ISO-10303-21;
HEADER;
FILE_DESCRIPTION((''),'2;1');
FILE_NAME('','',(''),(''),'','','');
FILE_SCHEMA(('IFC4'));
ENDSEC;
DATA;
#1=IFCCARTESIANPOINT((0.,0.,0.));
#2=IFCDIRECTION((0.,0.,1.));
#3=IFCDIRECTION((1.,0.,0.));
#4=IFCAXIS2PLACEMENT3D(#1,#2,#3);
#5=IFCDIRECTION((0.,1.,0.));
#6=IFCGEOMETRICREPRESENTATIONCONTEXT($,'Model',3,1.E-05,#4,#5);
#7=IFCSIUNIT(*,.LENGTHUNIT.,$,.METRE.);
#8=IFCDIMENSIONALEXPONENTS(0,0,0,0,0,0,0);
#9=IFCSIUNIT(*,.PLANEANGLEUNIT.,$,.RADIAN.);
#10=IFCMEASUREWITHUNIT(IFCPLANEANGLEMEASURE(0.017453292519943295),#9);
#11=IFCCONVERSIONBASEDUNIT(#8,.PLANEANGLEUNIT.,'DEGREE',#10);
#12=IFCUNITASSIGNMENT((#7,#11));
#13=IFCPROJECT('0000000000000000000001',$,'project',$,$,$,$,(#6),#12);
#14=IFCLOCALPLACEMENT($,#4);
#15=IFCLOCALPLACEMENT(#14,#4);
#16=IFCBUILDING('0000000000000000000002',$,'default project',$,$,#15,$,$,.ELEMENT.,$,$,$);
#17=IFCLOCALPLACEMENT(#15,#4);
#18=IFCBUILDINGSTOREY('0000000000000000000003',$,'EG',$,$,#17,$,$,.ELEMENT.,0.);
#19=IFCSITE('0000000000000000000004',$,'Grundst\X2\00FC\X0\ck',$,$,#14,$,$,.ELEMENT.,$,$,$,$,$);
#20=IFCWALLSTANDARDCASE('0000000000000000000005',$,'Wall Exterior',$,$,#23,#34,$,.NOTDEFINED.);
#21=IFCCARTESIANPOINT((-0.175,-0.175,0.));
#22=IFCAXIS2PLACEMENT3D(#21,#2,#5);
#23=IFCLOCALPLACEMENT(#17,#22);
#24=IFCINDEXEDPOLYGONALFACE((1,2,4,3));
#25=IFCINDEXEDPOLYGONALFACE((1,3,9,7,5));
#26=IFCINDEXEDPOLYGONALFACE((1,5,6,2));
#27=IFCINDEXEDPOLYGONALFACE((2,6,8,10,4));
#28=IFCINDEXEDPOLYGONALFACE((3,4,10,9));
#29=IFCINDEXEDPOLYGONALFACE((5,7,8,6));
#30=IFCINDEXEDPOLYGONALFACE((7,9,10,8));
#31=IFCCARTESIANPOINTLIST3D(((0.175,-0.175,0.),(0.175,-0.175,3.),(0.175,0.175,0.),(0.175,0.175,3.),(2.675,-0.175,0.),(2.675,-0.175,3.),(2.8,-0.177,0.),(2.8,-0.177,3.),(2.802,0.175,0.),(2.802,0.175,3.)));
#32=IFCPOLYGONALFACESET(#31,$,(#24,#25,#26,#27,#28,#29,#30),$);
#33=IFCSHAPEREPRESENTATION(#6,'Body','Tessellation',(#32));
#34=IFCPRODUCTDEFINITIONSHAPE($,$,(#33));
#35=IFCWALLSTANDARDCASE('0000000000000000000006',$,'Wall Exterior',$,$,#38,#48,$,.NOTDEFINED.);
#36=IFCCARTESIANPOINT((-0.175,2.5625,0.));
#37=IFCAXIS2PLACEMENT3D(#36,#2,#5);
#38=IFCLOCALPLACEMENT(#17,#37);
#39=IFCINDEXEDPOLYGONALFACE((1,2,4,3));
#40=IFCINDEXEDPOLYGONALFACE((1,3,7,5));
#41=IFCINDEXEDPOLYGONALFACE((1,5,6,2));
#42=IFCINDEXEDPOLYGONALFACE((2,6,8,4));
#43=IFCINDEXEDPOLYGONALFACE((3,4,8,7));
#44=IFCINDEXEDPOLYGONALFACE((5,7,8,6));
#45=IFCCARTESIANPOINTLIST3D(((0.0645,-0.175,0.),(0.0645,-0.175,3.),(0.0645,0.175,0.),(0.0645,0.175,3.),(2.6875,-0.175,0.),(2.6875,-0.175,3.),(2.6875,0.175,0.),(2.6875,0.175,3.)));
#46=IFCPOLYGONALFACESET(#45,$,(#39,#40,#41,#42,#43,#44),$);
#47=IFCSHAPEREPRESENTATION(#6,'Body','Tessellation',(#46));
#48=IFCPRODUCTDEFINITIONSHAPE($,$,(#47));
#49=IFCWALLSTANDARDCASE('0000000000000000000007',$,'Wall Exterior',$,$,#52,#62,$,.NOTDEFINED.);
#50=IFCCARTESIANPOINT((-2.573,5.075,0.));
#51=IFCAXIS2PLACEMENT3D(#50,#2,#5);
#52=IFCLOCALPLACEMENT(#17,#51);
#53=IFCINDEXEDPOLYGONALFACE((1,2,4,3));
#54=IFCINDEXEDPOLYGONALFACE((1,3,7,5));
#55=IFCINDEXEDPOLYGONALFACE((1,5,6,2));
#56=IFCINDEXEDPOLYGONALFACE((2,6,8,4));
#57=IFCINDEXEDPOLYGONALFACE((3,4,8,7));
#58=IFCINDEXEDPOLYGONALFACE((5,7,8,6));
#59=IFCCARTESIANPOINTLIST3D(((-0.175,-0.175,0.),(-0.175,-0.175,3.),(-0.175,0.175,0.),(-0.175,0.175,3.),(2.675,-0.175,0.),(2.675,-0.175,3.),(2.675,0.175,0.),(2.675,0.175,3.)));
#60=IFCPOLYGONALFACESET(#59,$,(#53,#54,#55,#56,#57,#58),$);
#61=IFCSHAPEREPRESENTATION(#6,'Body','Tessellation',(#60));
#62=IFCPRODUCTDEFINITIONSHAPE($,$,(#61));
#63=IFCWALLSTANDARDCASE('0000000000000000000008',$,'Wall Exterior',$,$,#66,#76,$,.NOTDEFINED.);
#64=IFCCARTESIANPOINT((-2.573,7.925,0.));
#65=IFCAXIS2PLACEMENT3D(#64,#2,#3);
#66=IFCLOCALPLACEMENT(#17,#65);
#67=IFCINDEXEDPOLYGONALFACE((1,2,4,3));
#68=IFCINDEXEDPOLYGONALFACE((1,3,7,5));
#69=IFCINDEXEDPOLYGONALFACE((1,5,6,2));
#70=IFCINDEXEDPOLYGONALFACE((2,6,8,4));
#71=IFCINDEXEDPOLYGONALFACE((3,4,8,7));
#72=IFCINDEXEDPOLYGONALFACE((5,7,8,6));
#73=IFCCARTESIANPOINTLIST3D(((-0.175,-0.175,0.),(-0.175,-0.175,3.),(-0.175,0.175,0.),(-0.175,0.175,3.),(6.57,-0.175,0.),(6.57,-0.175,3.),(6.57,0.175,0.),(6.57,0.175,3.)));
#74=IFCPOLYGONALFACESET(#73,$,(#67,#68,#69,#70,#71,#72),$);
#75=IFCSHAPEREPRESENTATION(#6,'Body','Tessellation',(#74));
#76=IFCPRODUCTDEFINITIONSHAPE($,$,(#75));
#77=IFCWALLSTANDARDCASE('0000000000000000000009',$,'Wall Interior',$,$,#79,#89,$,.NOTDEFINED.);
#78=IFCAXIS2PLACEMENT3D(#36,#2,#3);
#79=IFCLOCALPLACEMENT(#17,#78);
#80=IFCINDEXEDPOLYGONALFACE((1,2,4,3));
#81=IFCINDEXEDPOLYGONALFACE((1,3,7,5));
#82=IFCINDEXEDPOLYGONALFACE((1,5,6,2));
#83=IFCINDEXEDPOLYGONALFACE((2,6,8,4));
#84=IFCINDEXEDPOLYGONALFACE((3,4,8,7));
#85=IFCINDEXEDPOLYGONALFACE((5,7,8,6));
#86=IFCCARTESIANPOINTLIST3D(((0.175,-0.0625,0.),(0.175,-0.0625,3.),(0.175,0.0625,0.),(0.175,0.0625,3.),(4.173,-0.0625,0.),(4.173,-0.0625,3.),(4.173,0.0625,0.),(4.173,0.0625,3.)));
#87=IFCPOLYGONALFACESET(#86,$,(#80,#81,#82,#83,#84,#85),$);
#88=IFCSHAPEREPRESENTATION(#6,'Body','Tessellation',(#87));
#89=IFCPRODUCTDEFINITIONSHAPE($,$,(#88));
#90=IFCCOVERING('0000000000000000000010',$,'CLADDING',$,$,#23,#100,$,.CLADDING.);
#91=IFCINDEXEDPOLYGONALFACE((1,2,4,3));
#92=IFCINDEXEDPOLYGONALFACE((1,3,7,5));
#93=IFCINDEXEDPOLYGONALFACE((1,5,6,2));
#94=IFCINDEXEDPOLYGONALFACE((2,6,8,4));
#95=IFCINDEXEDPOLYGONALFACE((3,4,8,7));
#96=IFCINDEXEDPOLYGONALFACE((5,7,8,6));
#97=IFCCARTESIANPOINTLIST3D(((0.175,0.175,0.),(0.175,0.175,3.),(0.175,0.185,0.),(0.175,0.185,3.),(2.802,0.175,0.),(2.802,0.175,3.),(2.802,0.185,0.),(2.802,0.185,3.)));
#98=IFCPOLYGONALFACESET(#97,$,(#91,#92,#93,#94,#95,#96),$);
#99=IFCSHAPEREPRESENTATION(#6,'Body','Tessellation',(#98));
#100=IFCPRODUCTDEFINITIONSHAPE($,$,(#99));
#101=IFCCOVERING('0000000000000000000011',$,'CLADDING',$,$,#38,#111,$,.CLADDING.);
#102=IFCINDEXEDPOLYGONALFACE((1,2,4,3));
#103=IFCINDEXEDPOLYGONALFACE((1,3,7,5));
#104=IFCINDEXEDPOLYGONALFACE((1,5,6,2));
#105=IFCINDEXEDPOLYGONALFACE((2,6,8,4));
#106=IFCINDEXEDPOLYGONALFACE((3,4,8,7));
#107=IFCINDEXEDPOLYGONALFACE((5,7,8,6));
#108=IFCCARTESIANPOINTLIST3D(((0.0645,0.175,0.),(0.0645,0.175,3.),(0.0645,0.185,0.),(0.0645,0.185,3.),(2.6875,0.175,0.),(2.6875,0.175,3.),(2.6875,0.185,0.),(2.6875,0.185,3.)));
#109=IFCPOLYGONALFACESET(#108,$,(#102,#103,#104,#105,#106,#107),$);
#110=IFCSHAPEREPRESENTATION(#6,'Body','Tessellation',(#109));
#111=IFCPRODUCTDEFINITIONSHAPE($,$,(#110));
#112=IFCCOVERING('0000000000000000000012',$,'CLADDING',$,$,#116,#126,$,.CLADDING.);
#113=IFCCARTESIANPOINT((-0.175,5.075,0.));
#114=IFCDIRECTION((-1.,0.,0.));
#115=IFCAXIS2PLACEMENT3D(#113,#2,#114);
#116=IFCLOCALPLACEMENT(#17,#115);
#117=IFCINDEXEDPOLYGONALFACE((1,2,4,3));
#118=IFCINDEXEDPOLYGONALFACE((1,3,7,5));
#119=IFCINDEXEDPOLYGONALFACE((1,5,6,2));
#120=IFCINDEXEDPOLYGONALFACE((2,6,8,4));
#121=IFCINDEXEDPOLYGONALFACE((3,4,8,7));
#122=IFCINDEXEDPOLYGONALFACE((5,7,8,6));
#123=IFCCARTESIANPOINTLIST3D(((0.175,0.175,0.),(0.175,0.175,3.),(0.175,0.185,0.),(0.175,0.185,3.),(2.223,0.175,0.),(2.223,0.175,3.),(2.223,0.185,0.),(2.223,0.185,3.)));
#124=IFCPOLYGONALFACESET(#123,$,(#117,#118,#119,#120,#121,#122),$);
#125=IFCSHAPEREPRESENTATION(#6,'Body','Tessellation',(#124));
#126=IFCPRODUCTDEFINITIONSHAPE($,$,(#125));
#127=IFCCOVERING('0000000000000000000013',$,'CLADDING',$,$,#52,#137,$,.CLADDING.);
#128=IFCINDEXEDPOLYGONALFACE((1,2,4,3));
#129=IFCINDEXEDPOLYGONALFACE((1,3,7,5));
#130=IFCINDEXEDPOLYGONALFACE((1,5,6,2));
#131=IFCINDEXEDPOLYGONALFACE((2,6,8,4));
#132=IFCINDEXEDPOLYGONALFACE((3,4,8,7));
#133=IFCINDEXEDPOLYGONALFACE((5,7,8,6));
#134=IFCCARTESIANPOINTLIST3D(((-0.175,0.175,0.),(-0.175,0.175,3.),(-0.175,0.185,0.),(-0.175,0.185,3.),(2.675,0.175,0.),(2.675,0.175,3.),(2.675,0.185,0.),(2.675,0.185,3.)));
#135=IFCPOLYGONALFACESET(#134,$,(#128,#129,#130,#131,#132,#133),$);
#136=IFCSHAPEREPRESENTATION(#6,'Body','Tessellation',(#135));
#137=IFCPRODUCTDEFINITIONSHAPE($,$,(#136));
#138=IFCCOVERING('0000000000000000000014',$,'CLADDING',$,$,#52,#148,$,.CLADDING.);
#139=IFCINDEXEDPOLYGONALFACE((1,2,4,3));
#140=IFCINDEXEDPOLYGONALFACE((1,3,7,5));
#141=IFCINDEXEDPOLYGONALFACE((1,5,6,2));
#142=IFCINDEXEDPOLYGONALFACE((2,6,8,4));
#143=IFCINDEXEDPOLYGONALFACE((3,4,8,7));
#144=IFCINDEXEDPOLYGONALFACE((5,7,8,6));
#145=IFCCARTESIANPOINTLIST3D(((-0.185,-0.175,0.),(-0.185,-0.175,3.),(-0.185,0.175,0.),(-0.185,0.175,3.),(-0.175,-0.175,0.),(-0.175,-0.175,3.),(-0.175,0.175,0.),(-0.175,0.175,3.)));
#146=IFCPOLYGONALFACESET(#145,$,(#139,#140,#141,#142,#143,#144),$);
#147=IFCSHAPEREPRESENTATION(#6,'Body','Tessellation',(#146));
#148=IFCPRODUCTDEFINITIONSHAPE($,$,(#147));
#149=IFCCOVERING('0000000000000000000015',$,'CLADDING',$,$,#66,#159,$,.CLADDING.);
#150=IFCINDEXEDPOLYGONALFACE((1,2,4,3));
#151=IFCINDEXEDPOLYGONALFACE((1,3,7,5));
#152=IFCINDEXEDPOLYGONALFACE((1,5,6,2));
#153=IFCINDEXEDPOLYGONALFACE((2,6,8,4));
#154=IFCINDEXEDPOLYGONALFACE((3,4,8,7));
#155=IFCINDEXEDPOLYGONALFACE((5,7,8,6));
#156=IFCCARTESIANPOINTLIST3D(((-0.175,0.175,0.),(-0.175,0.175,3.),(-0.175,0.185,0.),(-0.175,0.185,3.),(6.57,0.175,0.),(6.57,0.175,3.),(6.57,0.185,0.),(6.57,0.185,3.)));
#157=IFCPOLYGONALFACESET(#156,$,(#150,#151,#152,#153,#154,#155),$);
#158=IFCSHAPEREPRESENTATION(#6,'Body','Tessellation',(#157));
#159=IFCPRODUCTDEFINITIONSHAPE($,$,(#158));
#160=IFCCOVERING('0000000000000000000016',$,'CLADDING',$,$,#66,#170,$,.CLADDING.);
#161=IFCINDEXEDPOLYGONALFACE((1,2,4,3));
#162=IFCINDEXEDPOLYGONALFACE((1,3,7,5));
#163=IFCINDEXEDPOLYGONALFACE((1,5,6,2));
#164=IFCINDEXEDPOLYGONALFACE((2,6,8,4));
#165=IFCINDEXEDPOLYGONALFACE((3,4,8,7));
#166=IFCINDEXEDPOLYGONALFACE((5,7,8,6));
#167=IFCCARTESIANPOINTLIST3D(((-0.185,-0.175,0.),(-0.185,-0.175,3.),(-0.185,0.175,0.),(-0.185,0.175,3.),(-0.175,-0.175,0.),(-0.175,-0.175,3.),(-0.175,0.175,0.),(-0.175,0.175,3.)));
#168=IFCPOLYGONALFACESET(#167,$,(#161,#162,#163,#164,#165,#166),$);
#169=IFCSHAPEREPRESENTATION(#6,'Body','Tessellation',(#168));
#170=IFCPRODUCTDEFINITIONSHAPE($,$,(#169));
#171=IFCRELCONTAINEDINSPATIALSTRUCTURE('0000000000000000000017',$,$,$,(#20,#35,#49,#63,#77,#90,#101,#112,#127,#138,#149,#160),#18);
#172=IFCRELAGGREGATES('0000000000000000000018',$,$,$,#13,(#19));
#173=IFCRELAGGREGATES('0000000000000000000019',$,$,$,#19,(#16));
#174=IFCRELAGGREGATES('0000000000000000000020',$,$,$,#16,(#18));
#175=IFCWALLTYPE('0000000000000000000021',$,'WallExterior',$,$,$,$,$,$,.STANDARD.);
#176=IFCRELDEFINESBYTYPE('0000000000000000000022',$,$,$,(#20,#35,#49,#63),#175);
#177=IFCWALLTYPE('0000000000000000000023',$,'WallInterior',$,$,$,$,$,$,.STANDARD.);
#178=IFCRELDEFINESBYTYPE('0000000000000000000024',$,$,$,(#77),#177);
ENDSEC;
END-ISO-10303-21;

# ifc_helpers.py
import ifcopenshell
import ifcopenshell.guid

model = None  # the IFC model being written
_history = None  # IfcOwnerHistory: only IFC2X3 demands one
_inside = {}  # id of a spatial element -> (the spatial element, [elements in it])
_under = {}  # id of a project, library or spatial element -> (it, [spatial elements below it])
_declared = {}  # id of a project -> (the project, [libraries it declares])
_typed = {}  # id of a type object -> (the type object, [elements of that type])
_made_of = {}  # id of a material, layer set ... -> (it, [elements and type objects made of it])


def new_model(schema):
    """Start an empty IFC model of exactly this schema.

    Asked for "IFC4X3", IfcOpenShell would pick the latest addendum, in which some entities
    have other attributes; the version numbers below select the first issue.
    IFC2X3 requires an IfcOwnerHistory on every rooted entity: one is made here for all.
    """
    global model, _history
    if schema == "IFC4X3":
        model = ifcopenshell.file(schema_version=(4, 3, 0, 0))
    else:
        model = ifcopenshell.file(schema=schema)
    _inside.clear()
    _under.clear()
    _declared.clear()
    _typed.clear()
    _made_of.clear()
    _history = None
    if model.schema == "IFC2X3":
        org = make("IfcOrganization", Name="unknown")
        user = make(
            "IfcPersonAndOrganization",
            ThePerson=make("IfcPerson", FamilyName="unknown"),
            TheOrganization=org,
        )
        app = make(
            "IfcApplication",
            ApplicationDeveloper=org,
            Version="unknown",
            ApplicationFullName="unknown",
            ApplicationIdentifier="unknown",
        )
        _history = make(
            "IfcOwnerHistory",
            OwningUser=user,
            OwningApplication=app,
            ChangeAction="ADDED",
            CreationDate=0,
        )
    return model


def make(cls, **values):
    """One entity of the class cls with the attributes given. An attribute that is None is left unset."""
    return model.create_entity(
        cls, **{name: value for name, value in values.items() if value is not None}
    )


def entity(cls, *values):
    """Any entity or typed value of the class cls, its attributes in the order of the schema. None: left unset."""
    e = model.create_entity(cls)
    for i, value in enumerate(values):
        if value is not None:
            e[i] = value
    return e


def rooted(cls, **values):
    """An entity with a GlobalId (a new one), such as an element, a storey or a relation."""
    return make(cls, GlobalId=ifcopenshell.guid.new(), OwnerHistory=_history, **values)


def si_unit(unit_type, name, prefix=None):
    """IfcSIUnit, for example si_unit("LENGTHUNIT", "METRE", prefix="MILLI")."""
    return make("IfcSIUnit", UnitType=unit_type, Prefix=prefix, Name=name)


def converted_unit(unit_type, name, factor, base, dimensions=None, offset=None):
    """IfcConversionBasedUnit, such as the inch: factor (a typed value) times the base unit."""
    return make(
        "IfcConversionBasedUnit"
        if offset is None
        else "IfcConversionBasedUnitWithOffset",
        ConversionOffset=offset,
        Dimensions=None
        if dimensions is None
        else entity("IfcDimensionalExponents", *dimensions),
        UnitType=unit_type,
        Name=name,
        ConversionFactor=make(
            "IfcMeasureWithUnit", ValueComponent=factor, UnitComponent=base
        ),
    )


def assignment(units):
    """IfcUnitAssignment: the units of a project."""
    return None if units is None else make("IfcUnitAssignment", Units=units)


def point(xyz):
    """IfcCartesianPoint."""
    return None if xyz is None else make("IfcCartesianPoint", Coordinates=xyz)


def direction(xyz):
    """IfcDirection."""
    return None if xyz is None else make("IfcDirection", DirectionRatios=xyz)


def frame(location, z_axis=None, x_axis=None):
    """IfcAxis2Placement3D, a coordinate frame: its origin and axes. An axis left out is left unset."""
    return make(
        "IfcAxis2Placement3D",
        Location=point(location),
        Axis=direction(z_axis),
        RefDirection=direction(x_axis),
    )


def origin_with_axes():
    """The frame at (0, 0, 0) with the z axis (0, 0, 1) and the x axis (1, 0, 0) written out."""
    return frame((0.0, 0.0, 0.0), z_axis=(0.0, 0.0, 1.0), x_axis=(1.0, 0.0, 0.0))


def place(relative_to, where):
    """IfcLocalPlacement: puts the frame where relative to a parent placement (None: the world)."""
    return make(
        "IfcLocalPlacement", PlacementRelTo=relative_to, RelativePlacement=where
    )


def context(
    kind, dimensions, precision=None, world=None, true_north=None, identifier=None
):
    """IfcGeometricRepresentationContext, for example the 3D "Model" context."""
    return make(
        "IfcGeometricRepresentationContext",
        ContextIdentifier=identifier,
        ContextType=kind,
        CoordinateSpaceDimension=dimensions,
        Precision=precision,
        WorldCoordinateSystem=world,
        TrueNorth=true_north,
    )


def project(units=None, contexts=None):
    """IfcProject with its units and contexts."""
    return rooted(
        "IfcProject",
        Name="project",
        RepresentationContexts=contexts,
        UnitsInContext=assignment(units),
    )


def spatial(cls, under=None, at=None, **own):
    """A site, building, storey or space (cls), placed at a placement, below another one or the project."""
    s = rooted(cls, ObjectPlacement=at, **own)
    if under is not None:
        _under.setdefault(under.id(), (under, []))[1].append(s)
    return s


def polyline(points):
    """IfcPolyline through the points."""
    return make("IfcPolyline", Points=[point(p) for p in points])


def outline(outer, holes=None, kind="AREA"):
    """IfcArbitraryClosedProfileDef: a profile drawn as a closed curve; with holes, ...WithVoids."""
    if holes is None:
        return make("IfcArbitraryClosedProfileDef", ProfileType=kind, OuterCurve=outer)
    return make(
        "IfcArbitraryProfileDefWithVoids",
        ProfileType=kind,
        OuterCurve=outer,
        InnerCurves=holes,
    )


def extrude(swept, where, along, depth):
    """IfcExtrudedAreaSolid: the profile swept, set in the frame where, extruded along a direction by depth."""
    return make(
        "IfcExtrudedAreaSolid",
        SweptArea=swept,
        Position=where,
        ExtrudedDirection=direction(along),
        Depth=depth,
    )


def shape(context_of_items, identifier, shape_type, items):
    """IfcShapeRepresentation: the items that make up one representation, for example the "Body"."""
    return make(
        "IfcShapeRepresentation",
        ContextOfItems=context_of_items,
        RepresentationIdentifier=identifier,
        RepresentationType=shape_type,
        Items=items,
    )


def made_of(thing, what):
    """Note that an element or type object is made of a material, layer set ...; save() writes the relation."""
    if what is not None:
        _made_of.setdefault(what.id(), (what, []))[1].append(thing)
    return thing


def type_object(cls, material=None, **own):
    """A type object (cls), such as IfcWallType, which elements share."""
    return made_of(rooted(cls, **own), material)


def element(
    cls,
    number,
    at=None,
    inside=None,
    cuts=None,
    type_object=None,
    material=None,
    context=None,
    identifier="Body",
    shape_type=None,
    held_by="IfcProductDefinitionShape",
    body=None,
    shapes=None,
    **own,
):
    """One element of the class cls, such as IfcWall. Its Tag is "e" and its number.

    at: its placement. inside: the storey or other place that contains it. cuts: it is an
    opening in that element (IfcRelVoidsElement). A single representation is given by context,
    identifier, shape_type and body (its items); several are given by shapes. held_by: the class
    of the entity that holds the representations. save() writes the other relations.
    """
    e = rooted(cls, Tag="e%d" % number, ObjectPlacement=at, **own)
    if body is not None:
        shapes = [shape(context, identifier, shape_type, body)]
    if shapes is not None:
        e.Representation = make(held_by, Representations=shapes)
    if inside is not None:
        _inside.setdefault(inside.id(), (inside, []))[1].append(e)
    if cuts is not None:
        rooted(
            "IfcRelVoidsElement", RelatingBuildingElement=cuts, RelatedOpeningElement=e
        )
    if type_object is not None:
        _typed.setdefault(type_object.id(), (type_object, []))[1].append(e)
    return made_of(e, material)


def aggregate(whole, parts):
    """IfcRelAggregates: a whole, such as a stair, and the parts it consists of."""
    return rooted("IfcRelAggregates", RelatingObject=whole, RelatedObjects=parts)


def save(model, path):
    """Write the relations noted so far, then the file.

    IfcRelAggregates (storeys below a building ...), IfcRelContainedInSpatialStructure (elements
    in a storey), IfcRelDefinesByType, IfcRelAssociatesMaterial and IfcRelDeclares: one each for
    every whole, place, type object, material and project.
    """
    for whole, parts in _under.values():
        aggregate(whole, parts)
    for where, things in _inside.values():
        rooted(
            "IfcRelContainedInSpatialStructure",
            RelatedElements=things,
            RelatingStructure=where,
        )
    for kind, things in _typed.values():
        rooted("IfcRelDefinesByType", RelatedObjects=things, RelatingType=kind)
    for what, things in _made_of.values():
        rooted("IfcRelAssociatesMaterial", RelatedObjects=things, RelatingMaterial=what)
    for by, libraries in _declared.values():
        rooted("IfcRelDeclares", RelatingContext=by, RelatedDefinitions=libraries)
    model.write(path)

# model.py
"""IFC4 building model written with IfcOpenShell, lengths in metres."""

from ifc_helpers import new_model, entity, si_unit, converted_unit, direction, frame, origin_with_axes, place, context, project, spatial, polyline, outline, extrude, type_object, element, save


model = new_model("IFC4")

# Units and contexts
model_context = context("Model", 3, precision=1e-05, world=origin_with_axes(), true_north=direction((0.0, 1.0, 0.0)))
ifc_project = project(units=[si_unit("LENGTHUNIT", "METRE"), converted_unit("PLANEANGLEUNIT", "DEGREE", entity("IfcPlaneAngleMeasure", 0.017453292519943295), si_unit("PLANEANGLEUNIT", "RADIAN"), dimensions=[0, 0, 0, 0, 0, 0, 0])], contexts=[model_context])

# Site, building, storey
site_placement = place(None, origin_with_axes())
site = spatial("IfcSite", under=ifc_project, at=site_placement, Name="Grundstück", CompositionType="ELEMENT")
building_placement = place(site_placement, origin_with_axes())
building = spatial("IfcBuilding", under=site, at=building_placement, Name="default project", CompositionType="ELEMENT")
placement_1 = place(building_placement, origin_with_axes())
storey = spatial("IfcBuildingStorey", under=building, at=placement_1, Name="EG", CompositionType="ELEMENT", Elevation=0.0)

# Walls
wall_type_1 = type_object("IfcWallType", Name="WallExterior", PredefinedType="STANDARD")
placement_2 = place(placement_1, frame((-0.175, -0.175, 0.0), z_axis=(0.0, 0.0, 1.0), x_axis=(0.0, 1.0, 0.0)))
element("IfcWallStandardCase", 1, at=placement_2, inside=storey, type_object=wall_type_1, Name="Wall Exterior", PredefinedType="NOTDEFINED", context=model_context, shape_type="SweptSolid", body=[
    extrude(outline(polyline([(2.802, 0.175), (0.175, 0.175), (0.175, -0.175), (2.675, -0.175), (2.8, -0.177), (2.802, 0.175)])), origin_with_axes(), (0.0, 0.0, 1.0), 3.0),
])
placement_3 = place(placement_1, frame((-0.175, 2.5625, 0.0), z_axis=(0.0, 0.0, 1.0), x_axis=(0.0, 1.0, 0.0)))
element("IfcWallStandardCase", 2, at=placement_3, inside=storey, type_object=wall_type_1, Name="Wall Exterior", PredefinedType="NOTDEFINED", context=model_context, shape_type="SweptSolid", body=[
    extrude(outline(polyline([(0.0645, -0.175), (2.6875, -0.175), (2.6875, 0.175), (0.0645, 0.175), (0.0645, -0.175)])), origin_with_axes(), (0.0, 0.0, 1.0), 3.0),
])
placement_4 = place(placement_1, frame((-0.175, 5.075, 0.0), z_axis=(0.0, 0.0, 1.0), x_axis=(-1.0, 0.0, 0.0)))
placement_5 = place(placement_1, frame((-2.573, 5.075, 0.0), z_axis=(0.0, 0.0, 1.0), x_axis=(0.0, 1.0, 0.0)))
element("IfcWallStandardCase", 3, at=placement_5, inside=storey, type_object=wall_type_1, Name="Wall Exterior", PredefinedType="NOTDEFINED", context=model_context, shape_type="SweptSolid", body=[
    extrude(outline(polyline([(2.675, -0.175), (2.675, 0.175), (-0.175, 0.175), (-0.175, -0.175), (2.675, -0.175)])), origin_with_axes(), (0.0, 0.0, 1.0), 3.0),
])
placement_6 = place(placement_1, frame((-2.573, 7.925, 0.0), z_axis=(0.0, 0.0, 1.0), x_axis=(1.0, 0.0, 0.0)))
element("IfcWallStandardCase", 4, at=placement_6, inside=storey, type_object=wall_type_1, Name="Wall Exterior", PredefinedType="NOTDEFINED", context=model_context, shape_type="SweptSolid", body=[
    extrude(outline(polyline([(6.57, -0.175), (6.57, 0.175), (-0.175, 0.175), (-0.175, -0.175), (6.57, -0.175)])), origin_with_axes(), (0.0, 0.0, 1.0), 3.0),
])
wall_type_2 = type_object("IfcWallType", Name="WallInterior", PredefinedType="STANDARD")
wall_1_placement = place(placement_1, frame((-0.175, 2.5625, 0.0), z_axis=(0.0, 0.0, 1.0), x_axis=(1.0, 0.0, 0.0)))
element("IfcWallStandardCase", 5, at=wall_1_placement, inside=storey, type_object=wall_type_2, Name="Wall Interior", PredefinedType="NOTDEFINED", context=model_context, shape_type="SweptSolid", body=[
    extrude(outline(polyline([(4.173, 0.0625), (0.175, 0.0625), (0.175, -0.0625), (4.173, -0.0625), (4.173, 0.0625)])), origin_with_axes(), (0.0, 0.0, 1.0), 3.0),
])

# Coverings
element("IfcCovering", 6, at=placement_2, inside=storey, Name="CLADDING", PredefinedType="CLADDING", context=model_context, shape_type="SweptSolid", body=[
    extrude(outline(polyline([(2.802, 0.185), (0.175, 0.185), (0.175, 0.175), (2.802, 0.175), (2.802, 0.185)])), origin_with_axes(), (0.0, 0.0, 1.0), 3.0),
])
element("IfcCovering", 7, at=placement_3, inside=storey, Name="CLADDING", PredefinedType="CLADDING", context=model_context, shape_type="SweptSolid", body=[
    extrude(outline(polyline([(2.6875, 0.185), (0.0645, 0.185), (0.0645, 0.175), (2.6875, 0.175), (2.6875, 0.185)])), origin_with_axes(), (0.0, 0.0, 1.0), 3.0),
])
element("IfcCovering", 8, at=placement_4, inside=storey, Name="CLADDING", PredefinedType="CLADDING", context=model_context, shape_type="SweptSolid", body=[
    extrude(outline(polyline([(2.223, 0.185), (0.175, 0.185), (0.175, 0.175), (2.223, 0.175), (2.223, 0.185)])), origin_with_axes(), (0.0, 0.0, 1.0), 3.0),
])
element("IfcCovering", 9, at=placement_5, inside=storey, Name="CLADDING", PredefinedType="CLADDING", context=model_context, shape_type="SweptSolid", body=[
    extrude(outline(polyline([(2.675, 0.185), (-0.175, 0.185), (-0.175, 0.175), (2.675, 0.175), (2.675, 0.185)])), origin_with_axes(), (0.0, 0.0, 1.0), 3.0),
])
element("IfcCovering", 10, at=placement_5, inside=storey, Name="CLADDING", PredefinedType="CLADDING", context=model_context, shape_type="SweptSolid", body=[
    extrude(outline(polyline([(-0.185, 0.175), (-0.185, -0.175), (-0.175, -0.175), (-0.175, 0.175), (-0.185, 0.175)])), origin_with_axes(), (0.0, 0.0, 1.0), 3.0),
])
element("IfcCovering", 11, at=placement_6, inside=storey, Name="CLADDING", PredefinedType="CLADDING", context=model_context, shape_type="SweptSolid", body=[
    extrude(outline(polyline([(6.57, 0.185), (-0.175, 0.185), (-0.175, 0.175), (6.57, 0.175), (6.57, 0.185)])), origin_with_axes(), (0.0, 0.0, 1.0), 3.0),
])
element("IfcCovering", 12, at=placement_6, inside=storey, Name="CLADDING", PredefinedType="CLADDING", context=model_context, shape_type="SweptSolid", body=[
    extrude(outline(polyline([(-0.185, 0.175), (-0.185, -0.175), (-0.175, -0.175), (-0.175, 0.175), (-0.185, 0.175)])), origin_with_axes(), (0.0, 0.0, 1.0), 3.0),
])

save(model, "model.ifc")
